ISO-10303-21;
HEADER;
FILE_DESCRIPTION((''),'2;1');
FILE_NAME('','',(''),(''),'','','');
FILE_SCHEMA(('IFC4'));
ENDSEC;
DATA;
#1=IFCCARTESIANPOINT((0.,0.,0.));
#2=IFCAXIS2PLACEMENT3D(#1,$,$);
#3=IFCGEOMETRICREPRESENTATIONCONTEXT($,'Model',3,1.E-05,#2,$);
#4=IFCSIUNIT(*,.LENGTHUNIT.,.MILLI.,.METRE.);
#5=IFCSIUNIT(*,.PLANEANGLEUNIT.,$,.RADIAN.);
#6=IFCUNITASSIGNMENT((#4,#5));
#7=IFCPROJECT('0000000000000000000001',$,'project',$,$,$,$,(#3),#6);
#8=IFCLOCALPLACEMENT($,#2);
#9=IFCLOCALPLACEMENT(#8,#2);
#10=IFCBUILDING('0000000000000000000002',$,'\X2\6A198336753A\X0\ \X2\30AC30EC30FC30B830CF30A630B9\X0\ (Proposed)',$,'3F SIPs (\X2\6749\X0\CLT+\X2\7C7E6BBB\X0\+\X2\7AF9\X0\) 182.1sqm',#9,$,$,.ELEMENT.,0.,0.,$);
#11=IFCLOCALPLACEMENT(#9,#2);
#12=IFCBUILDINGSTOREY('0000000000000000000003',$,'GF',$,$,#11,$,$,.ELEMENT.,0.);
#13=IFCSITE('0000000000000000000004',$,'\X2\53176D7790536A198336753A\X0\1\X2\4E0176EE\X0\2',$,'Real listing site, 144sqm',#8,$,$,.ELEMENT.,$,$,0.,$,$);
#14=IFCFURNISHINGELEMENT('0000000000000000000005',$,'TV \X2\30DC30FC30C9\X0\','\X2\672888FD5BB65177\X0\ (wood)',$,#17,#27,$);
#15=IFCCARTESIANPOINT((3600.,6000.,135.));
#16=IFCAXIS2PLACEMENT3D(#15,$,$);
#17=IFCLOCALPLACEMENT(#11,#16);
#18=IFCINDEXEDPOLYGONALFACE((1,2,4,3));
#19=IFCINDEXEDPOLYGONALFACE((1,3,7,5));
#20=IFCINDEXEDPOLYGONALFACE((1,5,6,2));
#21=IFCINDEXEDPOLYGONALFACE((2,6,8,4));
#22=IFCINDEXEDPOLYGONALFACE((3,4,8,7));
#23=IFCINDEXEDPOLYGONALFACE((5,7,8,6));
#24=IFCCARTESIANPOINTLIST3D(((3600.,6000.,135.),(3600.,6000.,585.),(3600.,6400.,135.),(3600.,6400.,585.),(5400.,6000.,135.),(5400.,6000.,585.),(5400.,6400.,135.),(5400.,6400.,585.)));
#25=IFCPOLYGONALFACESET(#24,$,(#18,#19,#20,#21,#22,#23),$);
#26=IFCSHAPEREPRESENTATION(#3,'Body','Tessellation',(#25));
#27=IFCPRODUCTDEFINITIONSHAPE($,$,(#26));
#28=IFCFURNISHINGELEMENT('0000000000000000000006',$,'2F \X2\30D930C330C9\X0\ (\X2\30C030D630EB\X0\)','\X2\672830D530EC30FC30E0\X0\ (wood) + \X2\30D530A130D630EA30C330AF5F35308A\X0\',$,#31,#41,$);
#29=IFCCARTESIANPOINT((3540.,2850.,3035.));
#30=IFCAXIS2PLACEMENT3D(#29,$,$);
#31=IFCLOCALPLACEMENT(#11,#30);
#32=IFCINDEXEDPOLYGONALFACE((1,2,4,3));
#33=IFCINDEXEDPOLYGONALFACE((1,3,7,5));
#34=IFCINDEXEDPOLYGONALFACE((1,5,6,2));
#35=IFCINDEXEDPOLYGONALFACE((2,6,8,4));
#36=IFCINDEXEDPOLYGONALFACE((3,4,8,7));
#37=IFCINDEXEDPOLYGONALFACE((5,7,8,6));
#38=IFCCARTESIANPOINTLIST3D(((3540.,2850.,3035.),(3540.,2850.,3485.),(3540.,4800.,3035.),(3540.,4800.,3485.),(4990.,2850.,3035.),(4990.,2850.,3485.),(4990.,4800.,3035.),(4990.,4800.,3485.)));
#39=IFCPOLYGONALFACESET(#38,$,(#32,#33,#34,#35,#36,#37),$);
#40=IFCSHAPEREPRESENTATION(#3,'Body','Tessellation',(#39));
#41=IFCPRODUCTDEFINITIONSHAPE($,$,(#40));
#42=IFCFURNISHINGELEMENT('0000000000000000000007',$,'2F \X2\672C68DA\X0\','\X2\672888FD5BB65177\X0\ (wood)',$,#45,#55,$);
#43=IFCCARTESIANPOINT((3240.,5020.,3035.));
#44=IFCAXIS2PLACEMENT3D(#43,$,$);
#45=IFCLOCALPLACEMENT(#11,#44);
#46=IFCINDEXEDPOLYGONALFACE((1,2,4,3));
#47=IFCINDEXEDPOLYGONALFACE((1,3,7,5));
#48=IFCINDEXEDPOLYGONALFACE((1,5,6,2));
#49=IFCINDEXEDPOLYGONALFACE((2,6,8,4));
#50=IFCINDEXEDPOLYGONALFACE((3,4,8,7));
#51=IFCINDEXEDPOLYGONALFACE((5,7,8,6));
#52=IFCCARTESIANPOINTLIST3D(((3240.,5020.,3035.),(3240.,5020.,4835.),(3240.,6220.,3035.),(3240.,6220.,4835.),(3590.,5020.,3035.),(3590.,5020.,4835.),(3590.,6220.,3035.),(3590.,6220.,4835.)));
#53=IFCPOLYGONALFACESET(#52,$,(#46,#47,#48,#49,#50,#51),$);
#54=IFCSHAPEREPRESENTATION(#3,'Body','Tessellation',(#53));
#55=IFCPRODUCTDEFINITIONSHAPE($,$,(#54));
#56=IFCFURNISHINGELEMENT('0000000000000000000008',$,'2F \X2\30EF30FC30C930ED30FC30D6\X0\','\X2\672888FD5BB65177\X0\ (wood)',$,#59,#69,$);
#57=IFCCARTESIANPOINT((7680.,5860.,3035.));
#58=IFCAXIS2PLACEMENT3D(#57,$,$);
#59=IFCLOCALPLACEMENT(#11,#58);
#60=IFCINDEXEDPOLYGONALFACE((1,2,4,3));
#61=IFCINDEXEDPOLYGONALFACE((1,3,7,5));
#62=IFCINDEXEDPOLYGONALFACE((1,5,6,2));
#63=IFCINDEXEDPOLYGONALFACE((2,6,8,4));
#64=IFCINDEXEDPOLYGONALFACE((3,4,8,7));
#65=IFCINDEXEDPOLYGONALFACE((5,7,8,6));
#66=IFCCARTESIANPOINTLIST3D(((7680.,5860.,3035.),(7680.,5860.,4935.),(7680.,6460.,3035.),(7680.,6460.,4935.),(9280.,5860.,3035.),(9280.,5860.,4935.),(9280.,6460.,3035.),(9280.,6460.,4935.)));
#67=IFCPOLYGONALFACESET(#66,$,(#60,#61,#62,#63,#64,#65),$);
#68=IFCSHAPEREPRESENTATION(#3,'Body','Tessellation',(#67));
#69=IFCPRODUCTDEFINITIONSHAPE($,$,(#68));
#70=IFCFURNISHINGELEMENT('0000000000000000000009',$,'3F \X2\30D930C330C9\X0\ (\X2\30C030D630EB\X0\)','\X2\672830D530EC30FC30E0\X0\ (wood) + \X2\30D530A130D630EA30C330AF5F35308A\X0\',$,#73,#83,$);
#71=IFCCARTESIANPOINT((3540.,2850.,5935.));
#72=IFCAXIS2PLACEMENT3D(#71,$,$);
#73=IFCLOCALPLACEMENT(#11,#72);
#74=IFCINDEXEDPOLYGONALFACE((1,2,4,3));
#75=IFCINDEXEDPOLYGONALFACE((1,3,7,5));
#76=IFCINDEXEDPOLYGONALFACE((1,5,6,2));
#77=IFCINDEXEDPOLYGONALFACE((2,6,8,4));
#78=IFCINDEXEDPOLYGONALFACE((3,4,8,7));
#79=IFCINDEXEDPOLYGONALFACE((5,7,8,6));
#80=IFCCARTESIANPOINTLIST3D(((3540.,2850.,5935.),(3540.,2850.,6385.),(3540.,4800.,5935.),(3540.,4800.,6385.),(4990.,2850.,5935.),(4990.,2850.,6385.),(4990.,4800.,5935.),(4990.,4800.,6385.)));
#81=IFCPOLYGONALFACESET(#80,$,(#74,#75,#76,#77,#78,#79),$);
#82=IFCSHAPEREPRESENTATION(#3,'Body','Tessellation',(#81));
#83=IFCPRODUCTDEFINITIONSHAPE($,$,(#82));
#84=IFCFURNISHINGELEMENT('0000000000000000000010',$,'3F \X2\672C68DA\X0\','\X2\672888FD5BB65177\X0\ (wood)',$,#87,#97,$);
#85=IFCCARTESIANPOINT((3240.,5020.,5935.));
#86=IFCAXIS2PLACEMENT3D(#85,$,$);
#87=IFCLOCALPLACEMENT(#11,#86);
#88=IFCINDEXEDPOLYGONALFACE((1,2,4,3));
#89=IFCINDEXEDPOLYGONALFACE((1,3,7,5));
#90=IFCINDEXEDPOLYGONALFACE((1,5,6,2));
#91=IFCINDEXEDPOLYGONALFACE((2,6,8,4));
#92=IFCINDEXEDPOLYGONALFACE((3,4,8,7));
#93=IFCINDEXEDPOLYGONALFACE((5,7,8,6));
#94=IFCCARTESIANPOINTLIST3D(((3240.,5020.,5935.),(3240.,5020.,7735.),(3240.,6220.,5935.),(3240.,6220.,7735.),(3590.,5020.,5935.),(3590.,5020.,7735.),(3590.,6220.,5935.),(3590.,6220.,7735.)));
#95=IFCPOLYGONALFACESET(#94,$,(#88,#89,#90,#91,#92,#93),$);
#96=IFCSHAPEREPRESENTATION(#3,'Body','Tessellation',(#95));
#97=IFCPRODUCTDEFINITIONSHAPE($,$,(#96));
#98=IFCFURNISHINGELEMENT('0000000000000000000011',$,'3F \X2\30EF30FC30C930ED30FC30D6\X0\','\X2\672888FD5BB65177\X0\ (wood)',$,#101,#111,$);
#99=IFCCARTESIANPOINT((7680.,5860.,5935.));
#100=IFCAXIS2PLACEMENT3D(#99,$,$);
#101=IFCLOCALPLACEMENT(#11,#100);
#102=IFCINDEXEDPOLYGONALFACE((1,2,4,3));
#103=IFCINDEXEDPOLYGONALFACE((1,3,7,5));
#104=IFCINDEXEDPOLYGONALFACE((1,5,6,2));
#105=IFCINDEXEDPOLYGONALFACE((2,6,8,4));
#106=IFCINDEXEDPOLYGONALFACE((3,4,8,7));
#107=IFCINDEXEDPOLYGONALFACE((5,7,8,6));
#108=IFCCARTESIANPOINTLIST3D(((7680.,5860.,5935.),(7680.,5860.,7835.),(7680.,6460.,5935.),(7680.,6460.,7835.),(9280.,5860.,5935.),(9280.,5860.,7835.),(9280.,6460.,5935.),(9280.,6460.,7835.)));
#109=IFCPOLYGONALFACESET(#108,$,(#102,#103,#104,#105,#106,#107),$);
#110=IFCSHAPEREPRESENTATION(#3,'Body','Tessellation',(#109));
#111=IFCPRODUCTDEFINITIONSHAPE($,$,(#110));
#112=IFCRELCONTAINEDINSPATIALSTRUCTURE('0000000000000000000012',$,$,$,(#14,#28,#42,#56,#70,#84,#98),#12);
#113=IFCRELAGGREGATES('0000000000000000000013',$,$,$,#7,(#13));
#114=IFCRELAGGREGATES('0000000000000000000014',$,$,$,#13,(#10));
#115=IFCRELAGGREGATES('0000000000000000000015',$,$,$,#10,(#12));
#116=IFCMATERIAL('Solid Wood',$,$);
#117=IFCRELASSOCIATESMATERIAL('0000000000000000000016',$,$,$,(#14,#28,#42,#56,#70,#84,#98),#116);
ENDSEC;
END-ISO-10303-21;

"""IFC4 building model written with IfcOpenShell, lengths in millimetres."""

from ifc_helpers import new_model, si_unit, frame, frame_2d, origin, place, context, project, spatial, rectangle, extrude, material, element, save


model = new_model("IFC4")

# Units and contexts
model_context = context("Model", 3, precision=1e-05, world=origin())
ifc_project = project(units=[si_unit("LENGTHUNIT", "METRE", prefix="MILLI"), si_unit("PLANEANGLEUNIT", "RADIAN")], contexts=[model_context])

# Site, building, storey
site_placement = place(None, origin())
site = spatial("IfcSite", under=ifc_project, at=site_placement, Name="北海道標茶町1丁目2", ObjectType="Real listing site, 144sqm", CompositionType="ELEMENT", RefElevation=0.0)
building_placement = place(site_placement, origin())
building = spatial("IfcBuilding", under=site, at=building_placement, Name="標茶町 ガレージハウス (Proposed)", ObjectType="3F SIPs (杉CLT+籾殻+竹) 182.1sqm", CompositionType="ELEMENT", ElevationOfRefHeight=0.0, ElevationOfTerrain=0.0)
storey_placement = place(building_placement, origin())
storey = spatial("IfcBuildingStorey", under=building, at=storey_placement, Name="GF", CompositionType="ELEMENT", Elevation=0.0)

# Shared definitions
ifc_material_1 = material(Name="Solid Wood")

# Furnishing elements
furnishing_1_placement = place(storey_placement, frame((3600.0, 6000.0, 135.0)))
element("IfcFurnishingElement", 1, at=furnishing_1_placement, inside=storey, material=ifc_material_1, Name="TV ボード", Description="木製家具 (wood)", context=model_context, shape_type="SweptSolid", body=[
    extrude(rectangle(XDim=1800.0, YDim=400.0, at=frame_2d((900.0, 200.0))), frame((3600.0, 6000.0, 135.0)), (0.0, 0.0, 1.0), 450.0),
])
furnishing_2_placement = place(storey_placement, frame((3540.0, 2850.0, 3035.0)))
element("IfcFurnishingElement", 2, at=furnishing_2_placement, inside=storey, material=ifc_material_1, Name="2F ベッド (ダブル)", Description="木フレーム (wood) + ファブリック張り", context=model_context, shape_type="SweptSolid", body=[
    extrude(rectangle(XDim=1450.0, YDim=1950.0, at=frame_2d((725.0, 975.0))), frame((3540.0, 2850.0, 3035.0)), (0.0, 0.0, 1.0), 450.0),
])
furnishing_3_placement = place(storey_placement, frame((3240.0, 5020.0, 3035.0)))
element("IfcFurnishingElement", 3, at=furnishing_3_placement, inside=storey, material=ifc_material_1, Name="2F 本棚", Description="木製家具 (wood)", context=model_context, shape_type="SweptSolid", body=[
    extrude(rectangle(XDim=350.0, YDim=1200.0, at=frame_2d((175.0, 600.0))), frame((3240.0, 5020.0, 3035.0)), (0.0, 0.0, 1.0), 1800.0),
])
furnishing_4_placement = place(storey_placement, frame((7680.0, 5860.0, 3035.0)))
element("IfcFurnishingElement", 4, at=furnishing_4_placement, inside=storey, material=ifc_material_1, Name="2F ワードローブ", Description="木製家具 (wood)", context=model_context, shape_type="SweptSolid", body=[
    extrude(rectangle(XDim=1600.0, YDim=600.0, at=frame_2d((800.0, 300.0))), frame((7680.0, 5860.0, 3035.0)), (0.0, 0.0, 1.0), 1900.0),
])
furnishing_5_placement = place(storey_placement, frame((3540.0, 2850.0, 5935.0)))
element("IfcFurnishingElement", 5, at=furnishing_5_placement, inside=storey, material=ifc_material_1, Name="3F ベッド (ダブル)", Description="木フレーム (wood) + ファブリック張り", context=model_context, shape_type="SweptSolid", body=[
    extrude(rectangle(XDim=1450.0, YDim=1950.0, at=frame_2d((725.0, 975.0))), frame((3540.0, 2850.0, 5935.0)), (0.0, 0.0, 1.0), 450.0),
])
furnishing_6_placement = place(storey_placement, frame((3240.0, 5020.0, 5935.0)))
element("IfcFurnishingElement", 6, at=furnishing_6_placement, inside=storey, material=ifc_material_1, Name="3F 本棚", Description="木製家具 (wood)", context=model_context, shape_type="SweptSolid", body=[
    extrude(rectangle(XDim=350.0, YDim=1200.0, at=frame_2d((175.0, 600.0))), frame((3240.0, 5020.0, 5935.0)), (0.0, 0.0, 1.0), 1800.0),
])
furnishing_7_placement = place(storey_placement, frame((7680.0, 5860.0, 5935.0)))
element("IfcFurnishingElement", 7, at=furnishing_7_placement, inside=storey, material=ifc_material_1, Name="3F ワードローブ", Description="木製家具 (wood)", context=model_context, shape_type="SweptSolid", body=[
    extrude(rectangle(XDim=1600.0, YDim=600.0, at=frame_2d((800.0, 300.0))), frame((7680.0, 5860.0, 5935.0)), (0.0, 0.0, 1.0), 1900.0),
])

save(model, "model.ifc")
